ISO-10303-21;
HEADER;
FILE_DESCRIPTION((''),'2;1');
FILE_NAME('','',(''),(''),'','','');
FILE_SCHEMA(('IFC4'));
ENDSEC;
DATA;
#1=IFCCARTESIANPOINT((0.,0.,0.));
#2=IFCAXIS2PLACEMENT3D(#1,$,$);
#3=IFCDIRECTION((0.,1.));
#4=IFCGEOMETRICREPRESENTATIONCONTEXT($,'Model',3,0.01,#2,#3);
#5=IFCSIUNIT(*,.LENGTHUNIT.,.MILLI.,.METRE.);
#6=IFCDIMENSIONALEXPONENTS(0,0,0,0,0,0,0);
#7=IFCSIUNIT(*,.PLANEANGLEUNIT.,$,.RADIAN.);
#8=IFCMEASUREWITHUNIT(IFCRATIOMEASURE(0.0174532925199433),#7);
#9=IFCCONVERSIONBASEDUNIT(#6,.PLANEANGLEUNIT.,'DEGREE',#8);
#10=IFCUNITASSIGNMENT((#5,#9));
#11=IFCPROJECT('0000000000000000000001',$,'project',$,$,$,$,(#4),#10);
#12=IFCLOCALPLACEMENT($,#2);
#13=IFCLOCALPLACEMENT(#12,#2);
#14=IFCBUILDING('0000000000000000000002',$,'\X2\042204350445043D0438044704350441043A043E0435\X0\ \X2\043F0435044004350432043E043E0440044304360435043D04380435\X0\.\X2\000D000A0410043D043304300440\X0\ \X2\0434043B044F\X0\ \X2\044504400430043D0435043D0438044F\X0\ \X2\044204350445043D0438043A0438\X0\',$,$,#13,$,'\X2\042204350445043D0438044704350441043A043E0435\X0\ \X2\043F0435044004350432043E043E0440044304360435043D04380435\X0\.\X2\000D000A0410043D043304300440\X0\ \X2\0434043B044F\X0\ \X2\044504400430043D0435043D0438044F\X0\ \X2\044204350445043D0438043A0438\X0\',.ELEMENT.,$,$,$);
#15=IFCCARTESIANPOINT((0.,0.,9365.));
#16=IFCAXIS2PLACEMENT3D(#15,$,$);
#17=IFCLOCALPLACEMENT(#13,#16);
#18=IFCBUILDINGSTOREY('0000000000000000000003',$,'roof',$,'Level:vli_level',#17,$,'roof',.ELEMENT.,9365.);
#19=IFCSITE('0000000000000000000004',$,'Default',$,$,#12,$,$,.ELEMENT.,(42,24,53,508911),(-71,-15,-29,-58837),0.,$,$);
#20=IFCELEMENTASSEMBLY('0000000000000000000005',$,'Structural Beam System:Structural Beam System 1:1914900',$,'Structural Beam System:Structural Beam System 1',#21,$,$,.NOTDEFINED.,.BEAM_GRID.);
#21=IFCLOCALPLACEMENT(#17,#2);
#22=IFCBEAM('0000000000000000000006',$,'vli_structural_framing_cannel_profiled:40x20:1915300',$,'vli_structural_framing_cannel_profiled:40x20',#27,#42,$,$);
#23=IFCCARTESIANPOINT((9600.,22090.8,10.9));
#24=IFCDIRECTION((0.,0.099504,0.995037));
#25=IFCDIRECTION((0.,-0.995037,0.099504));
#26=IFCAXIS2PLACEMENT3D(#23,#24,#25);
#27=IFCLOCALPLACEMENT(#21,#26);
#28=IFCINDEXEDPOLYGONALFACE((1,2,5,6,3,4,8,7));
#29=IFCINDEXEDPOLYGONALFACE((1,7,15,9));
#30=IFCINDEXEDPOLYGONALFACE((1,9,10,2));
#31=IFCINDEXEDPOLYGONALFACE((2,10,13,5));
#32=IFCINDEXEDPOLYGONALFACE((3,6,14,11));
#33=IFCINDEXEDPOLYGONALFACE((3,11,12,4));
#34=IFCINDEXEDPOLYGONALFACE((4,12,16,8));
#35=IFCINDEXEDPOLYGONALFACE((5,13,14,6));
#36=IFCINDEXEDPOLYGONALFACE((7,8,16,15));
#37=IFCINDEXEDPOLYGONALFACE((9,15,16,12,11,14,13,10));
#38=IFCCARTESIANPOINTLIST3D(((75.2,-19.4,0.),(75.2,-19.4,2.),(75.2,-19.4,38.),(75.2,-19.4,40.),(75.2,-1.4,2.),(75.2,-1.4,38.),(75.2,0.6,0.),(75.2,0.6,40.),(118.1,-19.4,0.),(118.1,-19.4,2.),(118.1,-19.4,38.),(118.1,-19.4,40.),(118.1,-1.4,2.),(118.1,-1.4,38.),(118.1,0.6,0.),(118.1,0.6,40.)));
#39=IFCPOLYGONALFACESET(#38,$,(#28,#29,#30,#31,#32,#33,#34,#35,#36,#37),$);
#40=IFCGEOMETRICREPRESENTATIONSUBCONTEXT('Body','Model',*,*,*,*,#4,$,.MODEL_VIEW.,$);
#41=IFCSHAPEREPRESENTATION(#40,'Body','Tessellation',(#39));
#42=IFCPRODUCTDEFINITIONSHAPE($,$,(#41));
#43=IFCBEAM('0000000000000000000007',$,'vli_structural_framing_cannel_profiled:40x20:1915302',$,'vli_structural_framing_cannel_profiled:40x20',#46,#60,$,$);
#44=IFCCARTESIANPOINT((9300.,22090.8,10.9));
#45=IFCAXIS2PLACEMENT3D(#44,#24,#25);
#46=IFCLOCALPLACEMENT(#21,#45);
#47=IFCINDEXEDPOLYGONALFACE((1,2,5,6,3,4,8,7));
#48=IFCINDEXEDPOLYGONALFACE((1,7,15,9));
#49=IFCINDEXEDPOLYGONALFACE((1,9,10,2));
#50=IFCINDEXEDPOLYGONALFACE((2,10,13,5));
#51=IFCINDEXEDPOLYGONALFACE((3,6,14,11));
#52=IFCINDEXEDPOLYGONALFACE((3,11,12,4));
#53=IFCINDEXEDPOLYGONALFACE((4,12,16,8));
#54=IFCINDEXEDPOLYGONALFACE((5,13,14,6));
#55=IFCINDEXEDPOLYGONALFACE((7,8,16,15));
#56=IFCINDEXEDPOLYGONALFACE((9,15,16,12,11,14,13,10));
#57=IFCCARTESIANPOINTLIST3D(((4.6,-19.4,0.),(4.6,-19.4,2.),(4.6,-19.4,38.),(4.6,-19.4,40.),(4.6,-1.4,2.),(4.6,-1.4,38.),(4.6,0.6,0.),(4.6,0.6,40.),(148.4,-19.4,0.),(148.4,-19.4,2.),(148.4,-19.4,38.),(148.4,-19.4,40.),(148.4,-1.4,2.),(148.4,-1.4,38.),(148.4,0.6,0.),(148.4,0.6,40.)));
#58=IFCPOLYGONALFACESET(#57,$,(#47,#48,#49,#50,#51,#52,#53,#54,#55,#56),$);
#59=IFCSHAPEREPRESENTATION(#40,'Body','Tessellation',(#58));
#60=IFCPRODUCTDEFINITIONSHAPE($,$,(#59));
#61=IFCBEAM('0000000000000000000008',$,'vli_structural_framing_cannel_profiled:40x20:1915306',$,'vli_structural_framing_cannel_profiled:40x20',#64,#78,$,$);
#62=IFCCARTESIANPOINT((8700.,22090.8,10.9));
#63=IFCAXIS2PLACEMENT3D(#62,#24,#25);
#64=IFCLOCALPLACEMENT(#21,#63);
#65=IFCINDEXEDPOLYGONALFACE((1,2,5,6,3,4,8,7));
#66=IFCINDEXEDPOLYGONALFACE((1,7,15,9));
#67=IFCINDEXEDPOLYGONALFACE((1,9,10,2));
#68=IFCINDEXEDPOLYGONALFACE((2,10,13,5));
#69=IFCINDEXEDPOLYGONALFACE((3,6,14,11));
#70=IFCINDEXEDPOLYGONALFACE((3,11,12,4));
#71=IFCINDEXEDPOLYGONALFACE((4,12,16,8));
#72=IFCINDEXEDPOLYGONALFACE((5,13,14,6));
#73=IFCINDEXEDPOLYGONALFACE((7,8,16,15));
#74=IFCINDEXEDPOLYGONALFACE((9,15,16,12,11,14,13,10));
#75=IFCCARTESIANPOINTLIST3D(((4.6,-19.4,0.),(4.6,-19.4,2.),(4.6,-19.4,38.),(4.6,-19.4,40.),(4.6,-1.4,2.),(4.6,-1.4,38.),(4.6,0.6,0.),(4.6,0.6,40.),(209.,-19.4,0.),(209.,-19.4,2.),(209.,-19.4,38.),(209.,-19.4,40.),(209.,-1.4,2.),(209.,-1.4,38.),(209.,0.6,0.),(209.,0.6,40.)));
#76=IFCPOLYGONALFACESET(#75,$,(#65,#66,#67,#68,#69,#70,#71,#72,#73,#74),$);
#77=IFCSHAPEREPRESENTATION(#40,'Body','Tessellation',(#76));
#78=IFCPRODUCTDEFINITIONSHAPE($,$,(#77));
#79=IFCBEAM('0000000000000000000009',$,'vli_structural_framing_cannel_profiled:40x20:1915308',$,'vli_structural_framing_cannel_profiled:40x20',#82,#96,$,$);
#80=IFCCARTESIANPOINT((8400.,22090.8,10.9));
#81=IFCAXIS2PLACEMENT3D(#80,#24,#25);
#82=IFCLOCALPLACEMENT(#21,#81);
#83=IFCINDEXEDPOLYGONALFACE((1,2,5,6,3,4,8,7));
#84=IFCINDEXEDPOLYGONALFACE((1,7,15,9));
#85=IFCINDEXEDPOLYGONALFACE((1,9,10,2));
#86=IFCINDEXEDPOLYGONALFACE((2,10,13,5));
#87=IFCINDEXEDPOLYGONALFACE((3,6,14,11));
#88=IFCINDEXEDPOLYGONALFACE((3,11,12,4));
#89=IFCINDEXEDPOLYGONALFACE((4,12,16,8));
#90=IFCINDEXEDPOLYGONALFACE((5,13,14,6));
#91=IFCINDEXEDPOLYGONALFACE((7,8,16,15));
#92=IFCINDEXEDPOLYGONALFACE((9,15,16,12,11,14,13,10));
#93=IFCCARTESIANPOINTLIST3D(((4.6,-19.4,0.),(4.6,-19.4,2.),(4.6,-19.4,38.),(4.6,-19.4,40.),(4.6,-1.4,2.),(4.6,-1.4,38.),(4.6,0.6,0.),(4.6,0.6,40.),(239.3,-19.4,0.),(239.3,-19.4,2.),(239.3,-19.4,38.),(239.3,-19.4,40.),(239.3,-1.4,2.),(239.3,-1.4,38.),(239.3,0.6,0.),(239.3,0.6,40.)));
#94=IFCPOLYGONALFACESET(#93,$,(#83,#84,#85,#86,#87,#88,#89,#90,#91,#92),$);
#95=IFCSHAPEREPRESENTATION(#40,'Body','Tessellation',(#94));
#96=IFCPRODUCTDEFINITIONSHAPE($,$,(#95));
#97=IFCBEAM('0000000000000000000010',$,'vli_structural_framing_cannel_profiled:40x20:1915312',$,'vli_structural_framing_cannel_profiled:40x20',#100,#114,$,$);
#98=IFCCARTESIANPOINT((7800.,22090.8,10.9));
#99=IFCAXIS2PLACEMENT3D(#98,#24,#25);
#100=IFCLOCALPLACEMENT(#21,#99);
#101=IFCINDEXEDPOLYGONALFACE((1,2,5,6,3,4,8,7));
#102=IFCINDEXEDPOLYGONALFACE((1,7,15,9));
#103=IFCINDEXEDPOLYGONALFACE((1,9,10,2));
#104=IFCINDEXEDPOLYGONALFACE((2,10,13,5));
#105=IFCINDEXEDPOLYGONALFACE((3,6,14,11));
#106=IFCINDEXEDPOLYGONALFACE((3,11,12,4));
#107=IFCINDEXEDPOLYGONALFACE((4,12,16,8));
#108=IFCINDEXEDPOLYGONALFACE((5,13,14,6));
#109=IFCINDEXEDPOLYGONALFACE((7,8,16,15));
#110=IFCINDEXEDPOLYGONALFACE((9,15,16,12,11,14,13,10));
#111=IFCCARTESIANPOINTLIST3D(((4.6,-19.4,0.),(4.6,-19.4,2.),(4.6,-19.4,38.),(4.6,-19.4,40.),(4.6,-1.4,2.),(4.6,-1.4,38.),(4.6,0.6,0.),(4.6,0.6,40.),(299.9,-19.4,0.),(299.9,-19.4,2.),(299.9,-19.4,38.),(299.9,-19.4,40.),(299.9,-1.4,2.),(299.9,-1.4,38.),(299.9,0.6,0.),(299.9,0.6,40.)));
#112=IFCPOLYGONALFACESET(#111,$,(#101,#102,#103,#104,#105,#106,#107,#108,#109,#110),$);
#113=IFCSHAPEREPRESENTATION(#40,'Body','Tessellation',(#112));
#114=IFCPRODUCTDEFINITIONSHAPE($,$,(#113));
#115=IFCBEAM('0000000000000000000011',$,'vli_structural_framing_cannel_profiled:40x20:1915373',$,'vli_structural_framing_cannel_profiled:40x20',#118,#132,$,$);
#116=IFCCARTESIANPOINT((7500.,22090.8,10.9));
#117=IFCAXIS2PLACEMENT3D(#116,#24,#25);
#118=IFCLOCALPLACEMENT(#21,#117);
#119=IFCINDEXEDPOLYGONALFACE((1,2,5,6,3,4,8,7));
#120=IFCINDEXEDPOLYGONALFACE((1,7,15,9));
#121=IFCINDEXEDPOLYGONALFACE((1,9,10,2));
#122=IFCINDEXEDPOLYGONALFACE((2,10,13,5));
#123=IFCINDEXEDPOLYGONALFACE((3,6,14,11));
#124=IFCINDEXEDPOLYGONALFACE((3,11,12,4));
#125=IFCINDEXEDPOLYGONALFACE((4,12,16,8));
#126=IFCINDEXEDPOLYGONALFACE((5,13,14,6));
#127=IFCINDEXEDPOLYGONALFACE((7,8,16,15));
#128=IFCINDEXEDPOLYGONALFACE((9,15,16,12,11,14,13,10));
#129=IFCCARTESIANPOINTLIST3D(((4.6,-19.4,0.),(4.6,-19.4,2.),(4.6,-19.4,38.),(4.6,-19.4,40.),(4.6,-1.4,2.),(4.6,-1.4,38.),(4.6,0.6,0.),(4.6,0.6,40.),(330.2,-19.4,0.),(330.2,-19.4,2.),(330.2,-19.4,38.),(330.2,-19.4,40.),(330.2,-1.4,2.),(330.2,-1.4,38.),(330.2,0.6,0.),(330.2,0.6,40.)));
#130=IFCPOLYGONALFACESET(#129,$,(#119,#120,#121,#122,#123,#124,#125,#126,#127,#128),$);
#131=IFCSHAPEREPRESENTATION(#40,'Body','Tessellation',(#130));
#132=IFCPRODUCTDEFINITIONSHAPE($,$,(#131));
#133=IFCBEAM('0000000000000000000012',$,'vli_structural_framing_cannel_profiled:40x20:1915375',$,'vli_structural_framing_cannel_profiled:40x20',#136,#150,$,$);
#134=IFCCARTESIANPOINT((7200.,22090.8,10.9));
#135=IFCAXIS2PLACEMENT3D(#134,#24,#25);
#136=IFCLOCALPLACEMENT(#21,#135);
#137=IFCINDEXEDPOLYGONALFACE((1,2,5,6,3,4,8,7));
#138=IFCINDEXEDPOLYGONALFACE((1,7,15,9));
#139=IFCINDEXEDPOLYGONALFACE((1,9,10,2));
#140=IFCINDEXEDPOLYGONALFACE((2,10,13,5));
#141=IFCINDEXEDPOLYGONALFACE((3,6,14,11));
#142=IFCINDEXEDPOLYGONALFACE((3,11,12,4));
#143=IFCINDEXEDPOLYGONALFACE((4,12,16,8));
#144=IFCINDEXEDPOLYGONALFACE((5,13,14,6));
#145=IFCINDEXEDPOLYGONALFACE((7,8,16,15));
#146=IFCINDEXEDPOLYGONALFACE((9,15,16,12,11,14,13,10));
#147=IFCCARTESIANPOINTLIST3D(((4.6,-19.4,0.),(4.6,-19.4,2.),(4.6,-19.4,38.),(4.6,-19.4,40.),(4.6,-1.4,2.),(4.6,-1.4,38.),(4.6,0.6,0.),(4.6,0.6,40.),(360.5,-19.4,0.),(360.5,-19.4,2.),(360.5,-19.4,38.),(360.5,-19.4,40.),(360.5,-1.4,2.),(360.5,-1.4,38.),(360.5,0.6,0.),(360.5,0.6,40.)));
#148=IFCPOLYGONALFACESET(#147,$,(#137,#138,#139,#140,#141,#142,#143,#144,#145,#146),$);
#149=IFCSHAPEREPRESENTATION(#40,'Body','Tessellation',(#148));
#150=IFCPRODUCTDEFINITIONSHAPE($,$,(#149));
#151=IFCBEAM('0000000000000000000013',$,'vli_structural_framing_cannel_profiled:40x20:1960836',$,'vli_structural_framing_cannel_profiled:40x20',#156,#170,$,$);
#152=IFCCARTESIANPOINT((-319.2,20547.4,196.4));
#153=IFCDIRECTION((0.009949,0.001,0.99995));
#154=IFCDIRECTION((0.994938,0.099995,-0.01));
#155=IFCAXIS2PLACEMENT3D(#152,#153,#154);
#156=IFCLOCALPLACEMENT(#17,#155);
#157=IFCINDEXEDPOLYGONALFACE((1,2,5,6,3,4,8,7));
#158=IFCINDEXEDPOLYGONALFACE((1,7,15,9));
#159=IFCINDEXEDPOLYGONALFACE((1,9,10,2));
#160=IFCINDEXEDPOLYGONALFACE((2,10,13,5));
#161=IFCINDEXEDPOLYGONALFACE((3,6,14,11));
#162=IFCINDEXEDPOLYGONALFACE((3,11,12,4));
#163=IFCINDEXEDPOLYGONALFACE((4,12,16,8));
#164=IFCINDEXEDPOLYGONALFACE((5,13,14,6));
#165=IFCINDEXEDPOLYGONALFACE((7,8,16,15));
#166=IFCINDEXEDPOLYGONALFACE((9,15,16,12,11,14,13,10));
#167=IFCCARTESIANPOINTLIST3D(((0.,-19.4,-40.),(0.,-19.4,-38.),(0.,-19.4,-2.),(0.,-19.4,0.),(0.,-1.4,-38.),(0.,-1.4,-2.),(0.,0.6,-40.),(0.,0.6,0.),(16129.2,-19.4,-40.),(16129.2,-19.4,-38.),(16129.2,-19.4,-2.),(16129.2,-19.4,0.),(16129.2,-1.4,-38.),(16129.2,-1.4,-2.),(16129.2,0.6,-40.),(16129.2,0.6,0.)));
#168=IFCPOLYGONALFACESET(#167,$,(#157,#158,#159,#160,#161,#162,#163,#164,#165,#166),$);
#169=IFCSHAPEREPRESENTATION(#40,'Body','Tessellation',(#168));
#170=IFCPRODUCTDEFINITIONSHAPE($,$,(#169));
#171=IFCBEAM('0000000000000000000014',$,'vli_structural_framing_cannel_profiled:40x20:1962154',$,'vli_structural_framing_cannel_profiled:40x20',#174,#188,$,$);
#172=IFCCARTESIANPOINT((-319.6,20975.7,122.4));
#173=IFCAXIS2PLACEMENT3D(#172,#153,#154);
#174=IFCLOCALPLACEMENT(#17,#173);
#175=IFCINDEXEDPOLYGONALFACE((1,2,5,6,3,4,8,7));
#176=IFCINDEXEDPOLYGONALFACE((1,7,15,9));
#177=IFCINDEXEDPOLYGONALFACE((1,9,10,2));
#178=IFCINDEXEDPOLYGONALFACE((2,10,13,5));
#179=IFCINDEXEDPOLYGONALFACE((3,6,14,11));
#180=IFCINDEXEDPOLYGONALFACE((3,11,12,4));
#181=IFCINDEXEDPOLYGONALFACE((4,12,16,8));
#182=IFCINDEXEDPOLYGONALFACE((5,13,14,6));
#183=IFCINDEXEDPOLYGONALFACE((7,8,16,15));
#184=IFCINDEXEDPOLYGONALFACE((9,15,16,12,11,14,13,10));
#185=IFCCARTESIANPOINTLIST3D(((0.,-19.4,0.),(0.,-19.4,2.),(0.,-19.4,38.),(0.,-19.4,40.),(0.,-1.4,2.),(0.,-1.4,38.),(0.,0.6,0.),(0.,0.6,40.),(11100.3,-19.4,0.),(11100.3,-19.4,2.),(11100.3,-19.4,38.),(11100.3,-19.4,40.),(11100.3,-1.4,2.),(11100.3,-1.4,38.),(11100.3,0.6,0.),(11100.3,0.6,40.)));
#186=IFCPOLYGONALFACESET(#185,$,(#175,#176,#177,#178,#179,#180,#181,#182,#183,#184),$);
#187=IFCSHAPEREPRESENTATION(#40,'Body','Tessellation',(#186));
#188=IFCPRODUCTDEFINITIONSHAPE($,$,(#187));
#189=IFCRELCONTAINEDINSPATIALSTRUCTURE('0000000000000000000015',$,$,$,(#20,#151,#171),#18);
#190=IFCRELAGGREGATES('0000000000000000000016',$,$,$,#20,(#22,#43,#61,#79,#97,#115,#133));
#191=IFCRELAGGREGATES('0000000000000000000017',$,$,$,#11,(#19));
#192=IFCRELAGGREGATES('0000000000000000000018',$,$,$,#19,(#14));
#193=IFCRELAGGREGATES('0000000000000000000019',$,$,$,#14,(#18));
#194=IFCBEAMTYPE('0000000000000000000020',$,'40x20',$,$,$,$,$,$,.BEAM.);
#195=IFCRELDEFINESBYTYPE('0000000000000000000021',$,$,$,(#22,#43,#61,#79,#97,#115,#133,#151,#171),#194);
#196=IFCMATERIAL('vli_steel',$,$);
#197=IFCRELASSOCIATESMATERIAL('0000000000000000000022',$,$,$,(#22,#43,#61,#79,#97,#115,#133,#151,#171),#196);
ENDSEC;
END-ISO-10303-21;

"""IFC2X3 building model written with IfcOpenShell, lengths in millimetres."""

from ifc_helpers import new_model, entity, si_unit, converted_unit, direction, frame, origin, place, context, subcontext, project, spatial, polyline, outline, extrude, material, type_object, element, aggregate, save


model = new_model("IFC2X3")

# Units and contexts
model_context = context("Model", 3, precision=0.01, world=origin(), true_north=direction((0.0, 1.0)))
body_context = subcontext(model_context, "Body", "Model", "MODEL_VIEW")
ifc_project = project(units=[si_unit("LENGTHUNIT", "METRE", prefix="MILLI"), converted_unit("PLANEANGLEUNIT", "DEGREE", entity("IfcRatioMeasure", 0.0174532925199433), si_unit("PLANEANGLEUNIT", "RADIAN"), dimensions=[0, 0, 0, 0, 0, 0, 0])], contexts=[model_context])

# Site, building, storey
site_placement = place(None, origin())
site = spatial("IfcSite", under=ifc_project, at=site_placement, Name="Default", CompositionType="ELEMENT", RefLatitude=(42, 24, 53, 508911), RefLongitude=(-71, -15, -29, -58837), RefElevation=0.0)
building_placement = place(site_placement, origin())
building = spatial("IfcBuilding", under=site, at=building_placement, Name="Техническое перевооружение.\r\nАнгар для хранения техники", LongName="Техническое перевооружение.\r\nАнгар для хранения техники", CompositionType="ELEMENT")
storey_placement = place(building_placement, frame((0.0, 0.0, 9365.0)))
storey = spatial("IfcBuildingStorey", under=building, at=storey_placement, Name="roof", ObjectType="Level:vli_level", LongName="roof", CompositionType="ELEMENT", Elevation=9365.0)

# Shared definitions
ifc_material = material(Name="vli_steel")

# Element assembly, beams
assembly_placement = place(storey_placement, origin())
assembly = element("IfcElementAssembly", 1, at=assembly_placement, inside=storey, Name="Structural Beam System:Structural Beam System 1:1914900", ObjectType="Structural Beam System:Structural Beam System 1", AssemblyPlace="NOTDEFINED", PredefinedType="BEAM_GRID")
beam_type = type_object("IfcBeamType", Name="40x20", PredefinedType="BEAM")
beam_1_placement = place(assembly_placement, frame((9600.0, 22090.8, 10.9), z_axis=(0.0, 0.099504, 0.995037), x_axis=(0.0, -0.995037, 0.099504)))
beam_1 = element("IfcBeam", 2, at=beam_1_placement, type_object=beam_type, material=ifc_material, Name="vli_structural_framing_cannel_profiled:40x20:1915300", ObjectType="vli_structural_framing_cannel_profiled:40x20", context=body_context, shape_type="SweptSolid", body=[
    extrude(outline(polyline([(-20.0, -9.5), (-18.0, -9.5), (-18.0, 8.5), (18.0, 8.5), (18.0, -9.5), (20.0, -9.5), (20.0, 10.5), (-20.0, 10.5), (-20.0, -9.5)])), frame((75.2, -9.9, 20.0), z_axis=(1.0, 0.0, 0.0), x_axis=(0.0, 0.0, -1.0)), (0.0, 0.0, 1.0), 42.9),
])
beam_2_placement = place(assembly_placement, frame((9300.0, 22090.8, 10.9), z_axis=(0.0, 0.099504, 0.995037), x_axis=(0.0, -0.995037, 0.099504)))
beam_2 = element("IfcBeam", 3, at=beam_2_placement, type_object=beam_type, material=ifc_material, Name="vli_structural_framing_cannel_profiled:40x20:1915302", ObjectType="vli_structural_framing_cannel_profiled:40x20", context=body_context, shape_type="SweptSolid", body=[
    extrude(outline(polyline([(-20.0, -9.5), (-18.0, -9.5), (-18.0, 8.5), (18.0, 8.5), (18.0, -9.5), (20.0, -9.5), (20.0, 10.5), (-20.0, 10.5), (-20.0, -9.5)])), frame((4.6, -9.9, 20.0), z_axis=(1.0, 0.0, 0.0), x_axis=(0.0, 0.0, -1.0)), (0.0, 0.0, 1.0), 143.8),
])
beam_3_placement = place(assembly_placement, frame((8700.0, 22090.8, 10.9), z_axis=(0.0, 0.099504, 0.995037), x_axis=(0.0, -0.995037, 0.099504)))
beam_3 = element("IfcBeam", 4, at=beam_3_placement, type_object=beam_type, material=ifc_material, Name="vli_structural_framing_cannel_profiled:40x20:1915306", ObjectType="vli_structural_framing_cannel_profiled:40x20", context=body_context, shape_type="SweptSolid", body=[
    extrude(outline(polyline([(-20.0, -9.5), (-18.0, -9.5), (-18.0, 8.5), (18.0, 8.5), (18.0, -9.5), (20.0, -9.5), (20.0, 10.5), (-20.0, 10.5), (-20.0, -9.5)])), frame((4.6, -9.9, 20.0), z_axis=(1.0, 0.0, 0.0), x_axis=(0.0, 0.0, -1.0)), (0.0, 0.0, 1.0), 204.4),
])
beam_4_placement = place(assembly_placement, frame((8400.0, 22090.8, 10.9), z_axis=(0.0, 0.099504, 0.995037), x_axis=(0.0, -0.995037, 0.099504)))
beam_4 = element("IfcBeam", 5, at=beam_4_placement, type_object=beam_type, material=ifc_material, Name="vli_structural_framing_cannel_profiled:40x20:1915308", ObjectType="vli_structural_framing_cannel_profiled:40x20", context=body_context, shape_type="SweptSolid", body=[
    extrude(outline(polyline([(-20.0, -9.5), (-18.0, -9.5), (-18.0, 8.5), (18.0, 8.5), (18.0, -9.5), (20.0, -9.5), (20.0, 10.5), (-20.0, 10.5), (-20.0, -9.5)])), frame((4.6, -9.9, 20.0), z_axis=(1.0, 0.0, 0.0), x_axis=(0.0, 0.0, -1.0)), (0.0, 0.0, 1.0), 234.7),
])
beam_5_placement = place(assembly_placement, frame((7800.0, 22090.8, 10.9), z_axis=(0.0, 0.099504, 0.995037), x_axis=(0.0, -0.995037, 0.099504)))
beam_5 = element("IfcBeam", 6, at=beam_5_placement, type_object=beam_type, material=ifc_material, Name="vli_structural_framing_cannel_profiled:40x20:1915312", ObjectType="vli_structural_framing_cannel_profiled:40x20", context=body_context, shape_type="SweptSolid", body=[
    extrude(outline(polyline([(-20.0, -9.5), (-18.0, -9.5), (-18.0, 8.5), (18.0, 8.5), (18.0, -9.5), (20.0, -9.5), (20.0, 10.5), (-20.0, 10.5), (-20.0, -9.5)])), frame((4.6, -9.9, 20.0), z_axis=(1.0, 0.0, 0.0), x_axis=(0.0, 0.0, -1.0)), (0.0, 0.0, 1.0), 295.3),
])
beam_6_placement = place(assembly_placement, frame((7500.0, 22090.8, 10.9), z_axis=(0.0, 0.099504, 0.995037), x_axis=(0.0, -0.995037, 0.099504)))
beam_6 = element("IfcBeam", 7, at=beam_6_placement, type_object=beam_type, material=ifc_material, Name="vli_structural_framing_cannel_profiled:40x20:1915373", ObjectType="vli_structural_framing_cannel_profiled:40x20", context=body_context, shape_type="SweptSolid", body=[
    extrude(outline(polyline([(-20.0, -9.5), (-18.0, -9.5), (-18.0, 8.5), (18.0, 8.5), (18.0, -9.5), (20.0, -9.5), (20.0, 10.5), (-20.0, 10.5), (-20.0, -9.5)])), frame((4.6, -9.9, 20.0), z_axis=(1.0, 0.0, 0.0), x_axis=(0.0, 0.0, -1.0)), (0.0, 0.0, 1.0), 325.6),
])
beam_7_placement = place(assembly_placement, frame((7200.0, 22090.8, 10.9), z_axis=(0.0, 0.099504, 0.995037), x_axis=(0.0, -0.995037, 0.099504)))
beam_7 = element("IfcBeam", 8, at=beam_7_placement, type_object=beam_type, material=ifc_material, Name="vli_structural_framing_cannel_profiled:40x20:1915375", ObjectType="vli_structural_framing_cannel_profiled:40x20", context=body_context, shape_type="SweptSolid", body=[
    extrude(outline(polyline([(-20.0, -9.5), (-18.0, -9.5), (-18.0, 8.5), (18.0, 8.5), (18.0, -9.5), (20.0, -9.5), (20.0, 10.5), (-20.0, 10.5), (-20.0, -9.5)])), frame((4.6, -9.9, 20.0), z_axis=(1.0, 0.0, 0.0), x_axis=(0.0, 0.0, -1.0)), (0.0, 0.0, 1.0), 355.9),
])
aggregate(assembly, [beam_1, beam_2, beam_3, beam_4, beam_5, beam_6, beam_7])

# Beams
beam_8_placement = place(storey_placement, frame((-319.2, 20547.4, 196.4), z_axis=(0.009949, 0.001, 0.99995), x_axis=(0.994938, 0.099995, -0.01)))
element("IfcBeam", 9, at=beam_8_placement, inside=storey, type_object=beam_type, material=ifc_material, Name="vli_structural_framing_cannel_profiled:40x20:1960836", ObjectType="vli_structural_framing_cannel_profiled:40x20", context=body_context, shape_type="SweptSolid", body=[
    extrude(outline(polyline([(-20.0, -9.5), (-18.0, -9.5), (-18.0, 8.5), (18.0, 8.5), (18.0, -9.5), (20.0, -9.5), (20.0, 10.5), (-20.0, 10.5), (-20.0, -9.5)])), frame((0.0, -9.9, -20.0), z_axis=(1.0, 0.0, 0.0), x_axis=(0.0, 0.0, -1.0)), (0.0, 0.0, 1.0), 16129.2),
])
beam_9_placement = place(storey_placement, frame((-319.6, 20975.7, 122.4), z_axis=(0.009949, 0.001, 0.99995), x_axis=(0.994938, 0.099995, -0.01)))
element("IfcBeam", 10, at=beam_9_placement, inside=storey, type_object=beam_type, material=ifc_material, Name="vli_structural_framing_cannel_profiled:40x20:1962154", ObjectType="vli_structural_framing_cannel_profiled:40x20", context=body_context, shape_type="SweptSolid", body=[
    extrude(outline(polyline([(-20.0, -9.5), (-18.0, -9.5), (-18.0, 8.5), (18.0, 8.5), (18.0, -9.5), (20.0, -9.5), (20.0, 10.5), (-20.0, 10.5), (-20.0, -9.5)])), frame((0.0, -9.9, 20.0), z_axis=(1.0, 0.0, 0.0), x_axis=(0.0, 0.0, -1.0)), (0.0, 0.0, 1.0), 11100.3),
])

save(model, "model.ifc")
